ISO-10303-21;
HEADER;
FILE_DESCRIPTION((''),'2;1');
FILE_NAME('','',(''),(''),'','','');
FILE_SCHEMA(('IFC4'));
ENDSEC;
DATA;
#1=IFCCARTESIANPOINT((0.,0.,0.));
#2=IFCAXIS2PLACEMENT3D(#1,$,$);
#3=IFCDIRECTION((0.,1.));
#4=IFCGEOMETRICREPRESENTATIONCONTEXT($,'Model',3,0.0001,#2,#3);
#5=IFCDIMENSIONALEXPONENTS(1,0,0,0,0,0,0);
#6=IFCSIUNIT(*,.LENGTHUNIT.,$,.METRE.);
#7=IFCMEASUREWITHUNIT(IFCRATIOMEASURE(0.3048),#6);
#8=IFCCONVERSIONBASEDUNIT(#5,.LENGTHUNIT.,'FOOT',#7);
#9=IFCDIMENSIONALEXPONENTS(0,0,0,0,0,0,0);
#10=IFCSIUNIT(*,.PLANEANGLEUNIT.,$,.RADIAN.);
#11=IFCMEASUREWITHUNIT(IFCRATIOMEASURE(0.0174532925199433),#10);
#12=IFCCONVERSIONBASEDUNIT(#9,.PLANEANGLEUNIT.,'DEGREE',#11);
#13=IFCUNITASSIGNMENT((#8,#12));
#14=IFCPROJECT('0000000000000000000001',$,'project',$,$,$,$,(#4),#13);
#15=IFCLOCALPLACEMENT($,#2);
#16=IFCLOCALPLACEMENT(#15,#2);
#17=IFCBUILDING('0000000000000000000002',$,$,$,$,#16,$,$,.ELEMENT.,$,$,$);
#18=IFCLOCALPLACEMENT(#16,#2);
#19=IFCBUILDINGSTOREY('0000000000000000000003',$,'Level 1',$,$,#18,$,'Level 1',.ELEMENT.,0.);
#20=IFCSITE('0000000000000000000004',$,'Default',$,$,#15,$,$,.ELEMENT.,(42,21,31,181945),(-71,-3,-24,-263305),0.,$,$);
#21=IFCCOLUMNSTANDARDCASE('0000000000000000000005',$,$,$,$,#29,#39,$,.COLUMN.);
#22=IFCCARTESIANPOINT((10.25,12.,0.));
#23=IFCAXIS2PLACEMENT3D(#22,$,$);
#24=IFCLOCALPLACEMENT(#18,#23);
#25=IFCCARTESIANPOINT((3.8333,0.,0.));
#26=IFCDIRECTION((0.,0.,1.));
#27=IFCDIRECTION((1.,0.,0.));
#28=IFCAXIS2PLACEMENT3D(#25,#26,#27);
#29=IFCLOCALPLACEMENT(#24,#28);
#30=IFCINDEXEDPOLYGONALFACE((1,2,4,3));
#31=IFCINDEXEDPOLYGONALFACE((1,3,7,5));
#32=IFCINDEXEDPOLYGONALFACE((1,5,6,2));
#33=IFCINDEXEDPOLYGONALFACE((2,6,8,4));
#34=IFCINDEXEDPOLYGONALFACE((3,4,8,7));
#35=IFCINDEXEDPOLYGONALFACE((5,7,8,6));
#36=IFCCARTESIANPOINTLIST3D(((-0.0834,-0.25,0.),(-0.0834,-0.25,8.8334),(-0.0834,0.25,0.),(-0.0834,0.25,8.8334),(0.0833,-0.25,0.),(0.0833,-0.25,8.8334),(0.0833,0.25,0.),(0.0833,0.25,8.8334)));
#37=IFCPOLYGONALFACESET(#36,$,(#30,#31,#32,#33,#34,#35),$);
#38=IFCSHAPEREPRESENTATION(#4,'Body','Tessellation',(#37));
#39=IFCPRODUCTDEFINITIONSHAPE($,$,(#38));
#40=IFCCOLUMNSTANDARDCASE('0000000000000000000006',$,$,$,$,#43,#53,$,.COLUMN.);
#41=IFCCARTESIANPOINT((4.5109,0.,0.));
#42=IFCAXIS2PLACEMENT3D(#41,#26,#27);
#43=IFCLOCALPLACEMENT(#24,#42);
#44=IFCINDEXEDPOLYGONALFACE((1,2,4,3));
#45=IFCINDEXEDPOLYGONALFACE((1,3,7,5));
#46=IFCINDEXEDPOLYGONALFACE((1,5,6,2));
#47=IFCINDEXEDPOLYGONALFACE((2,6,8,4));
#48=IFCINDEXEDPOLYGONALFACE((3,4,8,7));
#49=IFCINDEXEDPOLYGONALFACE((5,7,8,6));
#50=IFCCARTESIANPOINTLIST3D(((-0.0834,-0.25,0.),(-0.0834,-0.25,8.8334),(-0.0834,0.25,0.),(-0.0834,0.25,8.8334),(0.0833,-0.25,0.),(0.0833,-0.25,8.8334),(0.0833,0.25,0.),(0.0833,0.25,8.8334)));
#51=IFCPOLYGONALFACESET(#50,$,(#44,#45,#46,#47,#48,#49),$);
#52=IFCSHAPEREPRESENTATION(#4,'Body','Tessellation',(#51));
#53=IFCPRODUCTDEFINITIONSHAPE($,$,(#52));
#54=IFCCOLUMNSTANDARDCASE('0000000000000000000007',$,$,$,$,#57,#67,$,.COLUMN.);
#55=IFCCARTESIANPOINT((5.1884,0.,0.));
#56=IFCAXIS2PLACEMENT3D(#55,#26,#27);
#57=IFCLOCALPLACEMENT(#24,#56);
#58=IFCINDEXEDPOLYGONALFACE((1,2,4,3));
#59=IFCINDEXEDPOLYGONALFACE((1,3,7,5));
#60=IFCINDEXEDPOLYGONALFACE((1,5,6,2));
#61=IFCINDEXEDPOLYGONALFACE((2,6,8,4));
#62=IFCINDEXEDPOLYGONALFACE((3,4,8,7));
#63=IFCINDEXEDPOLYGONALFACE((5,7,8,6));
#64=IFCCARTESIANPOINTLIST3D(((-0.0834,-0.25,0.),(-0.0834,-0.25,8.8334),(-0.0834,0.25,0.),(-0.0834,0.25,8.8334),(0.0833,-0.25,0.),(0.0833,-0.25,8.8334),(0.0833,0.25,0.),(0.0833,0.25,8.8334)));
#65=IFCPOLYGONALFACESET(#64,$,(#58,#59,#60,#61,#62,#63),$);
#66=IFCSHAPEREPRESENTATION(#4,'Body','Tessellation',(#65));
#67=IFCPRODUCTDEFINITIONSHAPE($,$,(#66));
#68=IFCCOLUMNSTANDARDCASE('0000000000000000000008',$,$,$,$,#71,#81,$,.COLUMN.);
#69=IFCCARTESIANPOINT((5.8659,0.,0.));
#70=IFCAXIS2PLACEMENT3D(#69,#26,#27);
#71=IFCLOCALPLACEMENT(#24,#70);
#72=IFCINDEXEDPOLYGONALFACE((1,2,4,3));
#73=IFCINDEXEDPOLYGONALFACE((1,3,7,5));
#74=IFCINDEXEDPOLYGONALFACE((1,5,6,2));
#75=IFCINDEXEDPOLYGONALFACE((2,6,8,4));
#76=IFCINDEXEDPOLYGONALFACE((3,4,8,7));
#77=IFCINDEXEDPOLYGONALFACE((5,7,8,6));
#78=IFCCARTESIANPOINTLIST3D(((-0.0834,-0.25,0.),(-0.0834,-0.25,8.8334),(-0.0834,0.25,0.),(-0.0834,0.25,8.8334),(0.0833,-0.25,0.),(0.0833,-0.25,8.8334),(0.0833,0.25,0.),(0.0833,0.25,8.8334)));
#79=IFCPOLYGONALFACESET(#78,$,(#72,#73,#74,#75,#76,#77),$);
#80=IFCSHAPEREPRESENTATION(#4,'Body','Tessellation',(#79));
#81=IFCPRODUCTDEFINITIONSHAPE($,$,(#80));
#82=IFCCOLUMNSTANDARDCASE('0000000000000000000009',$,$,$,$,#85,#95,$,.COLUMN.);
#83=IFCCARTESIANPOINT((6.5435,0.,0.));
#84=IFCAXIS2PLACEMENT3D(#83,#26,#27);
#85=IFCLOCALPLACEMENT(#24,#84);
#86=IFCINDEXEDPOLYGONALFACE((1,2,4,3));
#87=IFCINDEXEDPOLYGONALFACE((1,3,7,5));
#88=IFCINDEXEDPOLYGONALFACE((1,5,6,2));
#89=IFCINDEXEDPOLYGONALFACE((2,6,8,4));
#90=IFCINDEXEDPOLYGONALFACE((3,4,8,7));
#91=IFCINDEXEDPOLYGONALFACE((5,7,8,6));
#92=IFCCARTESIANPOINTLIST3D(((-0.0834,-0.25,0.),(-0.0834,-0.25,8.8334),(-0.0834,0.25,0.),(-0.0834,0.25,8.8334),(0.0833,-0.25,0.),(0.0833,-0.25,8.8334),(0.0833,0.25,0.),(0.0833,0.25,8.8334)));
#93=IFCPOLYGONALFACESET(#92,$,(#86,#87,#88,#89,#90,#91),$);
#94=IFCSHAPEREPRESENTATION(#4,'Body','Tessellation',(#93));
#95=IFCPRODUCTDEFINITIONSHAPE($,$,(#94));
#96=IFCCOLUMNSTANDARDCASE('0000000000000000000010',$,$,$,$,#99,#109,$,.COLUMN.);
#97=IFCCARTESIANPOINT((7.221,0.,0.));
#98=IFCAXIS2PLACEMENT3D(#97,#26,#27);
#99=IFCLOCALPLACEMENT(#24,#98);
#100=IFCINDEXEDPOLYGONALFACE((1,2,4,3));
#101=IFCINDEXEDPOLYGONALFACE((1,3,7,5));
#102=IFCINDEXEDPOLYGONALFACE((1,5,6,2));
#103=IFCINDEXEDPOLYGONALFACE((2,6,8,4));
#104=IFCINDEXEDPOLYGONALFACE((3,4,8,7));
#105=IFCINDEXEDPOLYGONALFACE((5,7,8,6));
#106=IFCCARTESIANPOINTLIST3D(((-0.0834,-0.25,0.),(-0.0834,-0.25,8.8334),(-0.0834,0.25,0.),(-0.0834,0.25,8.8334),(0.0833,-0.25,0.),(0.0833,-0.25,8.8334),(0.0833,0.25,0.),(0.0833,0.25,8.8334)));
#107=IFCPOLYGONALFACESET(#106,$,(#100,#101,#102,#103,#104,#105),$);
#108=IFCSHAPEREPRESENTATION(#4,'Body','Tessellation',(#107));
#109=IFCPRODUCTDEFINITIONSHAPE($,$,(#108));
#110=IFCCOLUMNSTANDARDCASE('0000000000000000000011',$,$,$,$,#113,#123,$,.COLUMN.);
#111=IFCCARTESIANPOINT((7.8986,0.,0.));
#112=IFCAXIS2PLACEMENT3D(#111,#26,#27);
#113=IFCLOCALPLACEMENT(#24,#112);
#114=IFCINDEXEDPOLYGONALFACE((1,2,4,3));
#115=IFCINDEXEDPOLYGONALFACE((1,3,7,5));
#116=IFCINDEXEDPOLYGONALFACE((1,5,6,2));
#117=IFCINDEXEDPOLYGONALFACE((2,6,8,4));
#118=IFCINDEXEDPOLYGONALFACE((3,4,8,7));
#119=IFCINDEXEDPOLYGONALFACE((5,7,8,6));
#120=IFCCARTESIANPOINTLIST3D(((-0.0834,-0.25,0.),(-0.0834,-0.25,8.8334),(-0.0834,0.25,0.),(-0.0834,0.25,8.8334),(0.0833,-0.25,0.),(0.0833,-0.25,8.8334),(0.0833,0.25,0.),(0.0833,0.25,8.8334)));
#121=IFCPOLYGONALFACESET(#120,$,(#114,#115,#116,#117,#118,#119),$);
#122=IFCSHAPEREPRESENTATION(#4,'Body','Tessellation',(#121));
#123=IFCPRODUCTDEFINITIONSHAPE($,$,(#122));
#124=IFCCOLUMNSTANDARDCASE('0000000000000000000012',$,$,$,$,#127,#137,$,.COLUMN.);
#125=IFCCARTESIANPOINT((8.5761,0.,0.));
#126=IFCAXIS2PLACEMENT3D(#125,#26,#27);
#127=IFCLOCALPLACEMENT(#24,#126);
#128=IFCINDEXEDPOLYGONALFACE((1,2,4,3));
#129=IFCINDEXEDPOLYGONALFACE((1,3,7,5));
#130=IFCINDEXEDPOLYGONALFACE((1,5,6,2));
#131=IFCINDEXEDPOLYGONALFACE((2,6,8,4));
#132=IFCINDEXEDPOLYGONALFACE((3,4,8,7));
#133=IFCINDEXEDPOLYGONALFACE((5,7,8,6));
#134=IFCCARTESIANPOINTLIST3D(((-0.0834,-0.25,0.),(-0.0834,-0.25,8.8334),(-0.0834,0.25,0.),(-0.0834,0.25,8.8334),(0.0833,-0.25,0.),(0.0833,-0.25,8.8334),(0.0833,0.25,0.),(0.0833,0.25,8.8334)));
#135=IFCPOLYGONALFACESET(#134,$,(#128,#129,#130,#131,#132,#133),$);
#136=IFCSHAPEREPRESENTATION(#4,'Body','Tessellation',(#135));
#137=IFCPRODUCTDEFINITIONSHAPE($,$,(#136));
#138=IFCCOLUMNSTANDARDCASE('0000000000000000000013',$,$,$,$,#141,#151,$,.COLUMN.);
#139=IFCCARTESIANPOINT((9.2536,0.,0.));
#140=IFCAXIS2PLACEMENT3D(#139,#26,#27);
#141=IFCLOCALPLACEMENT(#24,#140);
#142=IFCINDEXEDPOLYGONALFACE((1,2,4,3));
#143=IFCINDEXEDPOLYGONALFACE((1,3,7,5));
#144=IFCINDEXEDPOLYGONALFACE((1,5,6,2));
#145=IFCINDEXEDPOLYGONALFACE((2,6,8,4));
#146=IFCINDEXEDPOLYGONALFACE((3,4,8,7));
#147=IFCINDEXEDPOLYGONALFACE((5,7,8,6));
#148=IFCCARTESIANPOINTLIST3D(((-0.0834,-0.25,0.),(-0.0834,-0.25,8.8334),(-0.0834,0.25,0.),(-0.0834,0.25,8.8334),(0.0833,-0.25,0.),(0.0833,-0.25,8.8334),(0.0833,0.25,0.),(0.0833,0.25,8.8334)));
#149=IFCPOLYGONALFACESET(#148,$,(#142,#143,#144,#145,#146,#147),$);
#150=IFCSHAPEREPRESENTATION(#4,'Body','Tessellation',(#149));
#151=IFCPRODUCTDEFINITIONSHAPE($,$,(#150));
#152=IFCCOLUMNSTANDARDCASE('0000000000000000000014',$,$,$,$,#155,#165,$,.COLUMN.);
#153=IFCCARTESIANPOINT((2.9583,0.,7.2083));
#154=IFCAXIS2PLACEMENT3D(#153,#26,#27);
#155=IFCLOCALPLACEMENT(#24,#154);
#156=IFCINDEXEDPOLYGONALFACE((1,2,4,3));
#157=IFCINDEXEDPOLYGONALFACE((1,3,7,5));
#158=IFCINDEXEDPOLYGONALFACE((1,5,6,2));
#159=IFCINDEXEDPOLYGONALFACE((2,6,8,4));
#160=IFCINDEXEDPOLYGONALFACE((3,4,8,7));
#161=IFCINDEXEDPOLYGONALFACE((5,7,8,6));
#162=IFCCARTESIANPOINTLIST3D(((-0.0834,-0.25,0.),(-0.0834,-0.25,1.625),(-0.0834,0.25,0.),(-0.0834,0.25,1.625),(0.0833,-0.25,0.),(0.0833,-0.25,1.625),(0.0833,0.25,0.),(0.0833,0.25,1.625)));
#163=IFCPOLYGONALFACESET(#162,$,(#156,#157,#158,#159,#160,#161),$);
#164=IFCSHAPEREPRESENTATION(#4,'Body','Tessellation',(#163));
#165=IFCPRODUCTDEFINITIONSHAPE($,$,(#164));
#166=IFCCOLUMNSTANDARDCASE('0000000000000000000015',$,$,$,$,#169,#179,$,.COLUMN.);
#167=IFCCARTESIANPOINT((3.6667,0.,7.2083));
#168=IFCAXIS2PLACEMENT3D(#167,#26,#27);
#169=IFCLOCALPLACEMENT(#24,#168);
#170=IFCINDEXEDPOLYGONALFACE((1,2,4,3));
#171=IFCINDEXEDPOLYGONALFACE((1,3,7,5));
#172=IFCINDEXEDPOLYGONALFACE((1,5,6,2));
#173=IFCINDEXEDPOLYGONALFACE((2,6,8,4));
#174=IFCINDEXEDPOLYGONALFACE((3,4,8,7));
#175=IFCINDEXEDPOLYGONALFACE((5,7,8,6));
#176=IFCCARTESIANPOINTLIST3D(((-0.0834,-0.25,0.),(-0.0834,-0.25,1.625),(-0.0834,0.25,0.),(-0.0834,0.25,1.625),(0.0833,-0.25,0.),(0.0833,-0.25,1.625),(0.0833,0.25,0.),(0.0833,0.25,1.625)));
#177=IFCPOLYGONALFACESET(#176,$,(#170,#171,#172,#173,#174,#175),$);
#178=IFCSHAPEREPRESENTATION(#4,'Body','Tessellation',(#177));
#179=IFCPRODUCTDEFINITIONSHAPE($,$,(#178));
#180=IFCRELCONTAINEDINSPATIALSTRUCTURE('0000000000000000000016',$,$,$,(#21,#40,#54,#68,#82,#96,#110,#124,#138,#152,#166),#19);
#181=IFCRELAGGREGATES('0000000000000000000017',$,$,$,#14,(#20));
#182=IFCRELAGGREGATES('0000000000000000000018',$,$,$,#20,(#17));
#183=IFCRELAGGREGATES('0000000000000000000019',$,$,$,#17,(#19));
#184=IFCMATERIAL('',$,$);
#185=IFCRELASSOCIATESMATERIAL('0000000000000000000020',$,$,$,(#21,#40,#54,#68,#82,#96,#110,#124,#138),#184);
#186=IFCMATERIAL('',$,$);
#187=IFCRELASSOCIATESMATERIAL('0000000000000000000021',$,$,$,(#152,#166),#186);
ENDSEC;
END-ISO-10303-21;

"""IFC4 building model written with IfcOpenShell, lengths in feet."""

from ifc_helpers import new_model, entity, si_unit, converted_unit, direction, frame, origin, place, context, project, spatial, rectangle, extrude, material, element, save


model = new_model("IFC4")

# Units and contexts
model_context = context("Model", 3, precision=0.0001, world=origin(), true_north=direction((0.0, 1.0)))
ifc_project = project(units=[converted_unit("LENGTHUNIT", "FOOT", entity("IfcRatioMeasure", 0.3048), si_unit("LENGTHUNIT", "METRE"), dimensions=[1, 0, 0, 0, 0, 0, 0]), converted_unit("PLANEANGLEUNIT", "DEGREE", entity("IfcRatioMeasure", 0.0174532925199433), si_unit("PLANEANGLEUNIT", "RADIAN"), dimensions=[0, 0, 0, 0, 0, 0, 0])], contexts=[model_context])

# Site, building, storey
site_placement = place(None, origin())
site = spatial("IfcSite", under=ifc_project, at=site_placement, Name="Default", CompositionType="ELEMENT", RefLatitude=(42, 21, 31, 181945), RefLongitude=(-71, -3, -24, -263305), RefElevation=0.0)
building_placement = place(site_placement, origin())
building = spatial("IfcBuilding", under=site, at=building_placement, CompositionType="ELEMENT")
storey_placement = place(building_placement, origin())
storey = spatial("IfcBuildingStorey", under=building, at=storey_placement, Name="Level 1", LongName="Level 1", CompositionType="ELEMENT", Elevation=0.0)

# Columns
ifc_material_1 = material(Name="")
placement_1 = place(storey_placement, frame((10.25, 12.0, 0.0)))
for number, where, z_axis, x_axis in (
    (1, (3.8333, 0.0, 0.0), (0.0, 0.0, 1.0), (1.0, 0.0, 0.0)),
    (2, (4.5109, 0.0, 0.0), (0.0, 0.0, 1.0), (1.0, 0.0, 0.0)),
    (3, (5.1884, 0.0, 0.0), (0.0, 0.0, 1.0), (1.0, 0.0, 0.0)),
    (4, (5.8659, 0.0, 0.0), (0.0, 0.0, 1.0), (1.0, 0.0, 0.0)),
    (5, (6.5435, 0.0, 0.0), (0.0, 0.0, 1.0), (1.0, 0.0, 0.0)),
    (6, (7.221, 0.0, 0.0), (0.0, 0.0, 1.0), (1.0, 0.0, 0.0)),
    (7, (7.8986, 0.0, 0.0), (0.0, 0.0, 1.0), (1.0, 0.0, 0.0)),
    (8, (8.5761, 0.0, 0.0), (0.0, 0.0, 1.0), (1.0, 0.0, 0.0)),
    (9, (9.2536, 0.0, 0.0), (0.0, 0.0, 1.0), (1.0, 0.0, 0.0)),
):
    element("IfcColumnStandardCase", number, at=place(placement_1, frame(where, z_axis=z_axis, x_axis=x_axis)), inside=storey, material=ifc_material_1, PredefinedType="COLUMN", context=model_context, shape_type="SweptSolid", body=[
        extrude(rectangle(XDim=0.1667, YDim=0.5), origin(), (0.0, 0.0, 1.0), 8.8334),
    ])
ifc_material_2 = material(Name="")
for number, where, z_axis, x_axis in (
    (10, (2.9583, 0.0, 7.2083), (0.0, 0.0, 1.0), (1.0, 0.0, 0.0)),
    (11, (3.6667, 0.0, 7.2083), (0.0, 0.0, 1.0), (1.0, 0.0, 0.0)),
):
    element("IfcColumnStandardCase", number, at=place(placement_1, frame(where, z_axis=z_axis, x_axis=x_axis)), inside=storey, material=ifc_material_2, PredefinedType="COLUMN", context=model_context, shape_type="SweptSolid", body=[
        extrude(rectangle(XDim=0.1667, YDim=0.5), origin(), (0.0, 0.0, 1.0), 1.625),
    ])

save(model, "model.ifc")
